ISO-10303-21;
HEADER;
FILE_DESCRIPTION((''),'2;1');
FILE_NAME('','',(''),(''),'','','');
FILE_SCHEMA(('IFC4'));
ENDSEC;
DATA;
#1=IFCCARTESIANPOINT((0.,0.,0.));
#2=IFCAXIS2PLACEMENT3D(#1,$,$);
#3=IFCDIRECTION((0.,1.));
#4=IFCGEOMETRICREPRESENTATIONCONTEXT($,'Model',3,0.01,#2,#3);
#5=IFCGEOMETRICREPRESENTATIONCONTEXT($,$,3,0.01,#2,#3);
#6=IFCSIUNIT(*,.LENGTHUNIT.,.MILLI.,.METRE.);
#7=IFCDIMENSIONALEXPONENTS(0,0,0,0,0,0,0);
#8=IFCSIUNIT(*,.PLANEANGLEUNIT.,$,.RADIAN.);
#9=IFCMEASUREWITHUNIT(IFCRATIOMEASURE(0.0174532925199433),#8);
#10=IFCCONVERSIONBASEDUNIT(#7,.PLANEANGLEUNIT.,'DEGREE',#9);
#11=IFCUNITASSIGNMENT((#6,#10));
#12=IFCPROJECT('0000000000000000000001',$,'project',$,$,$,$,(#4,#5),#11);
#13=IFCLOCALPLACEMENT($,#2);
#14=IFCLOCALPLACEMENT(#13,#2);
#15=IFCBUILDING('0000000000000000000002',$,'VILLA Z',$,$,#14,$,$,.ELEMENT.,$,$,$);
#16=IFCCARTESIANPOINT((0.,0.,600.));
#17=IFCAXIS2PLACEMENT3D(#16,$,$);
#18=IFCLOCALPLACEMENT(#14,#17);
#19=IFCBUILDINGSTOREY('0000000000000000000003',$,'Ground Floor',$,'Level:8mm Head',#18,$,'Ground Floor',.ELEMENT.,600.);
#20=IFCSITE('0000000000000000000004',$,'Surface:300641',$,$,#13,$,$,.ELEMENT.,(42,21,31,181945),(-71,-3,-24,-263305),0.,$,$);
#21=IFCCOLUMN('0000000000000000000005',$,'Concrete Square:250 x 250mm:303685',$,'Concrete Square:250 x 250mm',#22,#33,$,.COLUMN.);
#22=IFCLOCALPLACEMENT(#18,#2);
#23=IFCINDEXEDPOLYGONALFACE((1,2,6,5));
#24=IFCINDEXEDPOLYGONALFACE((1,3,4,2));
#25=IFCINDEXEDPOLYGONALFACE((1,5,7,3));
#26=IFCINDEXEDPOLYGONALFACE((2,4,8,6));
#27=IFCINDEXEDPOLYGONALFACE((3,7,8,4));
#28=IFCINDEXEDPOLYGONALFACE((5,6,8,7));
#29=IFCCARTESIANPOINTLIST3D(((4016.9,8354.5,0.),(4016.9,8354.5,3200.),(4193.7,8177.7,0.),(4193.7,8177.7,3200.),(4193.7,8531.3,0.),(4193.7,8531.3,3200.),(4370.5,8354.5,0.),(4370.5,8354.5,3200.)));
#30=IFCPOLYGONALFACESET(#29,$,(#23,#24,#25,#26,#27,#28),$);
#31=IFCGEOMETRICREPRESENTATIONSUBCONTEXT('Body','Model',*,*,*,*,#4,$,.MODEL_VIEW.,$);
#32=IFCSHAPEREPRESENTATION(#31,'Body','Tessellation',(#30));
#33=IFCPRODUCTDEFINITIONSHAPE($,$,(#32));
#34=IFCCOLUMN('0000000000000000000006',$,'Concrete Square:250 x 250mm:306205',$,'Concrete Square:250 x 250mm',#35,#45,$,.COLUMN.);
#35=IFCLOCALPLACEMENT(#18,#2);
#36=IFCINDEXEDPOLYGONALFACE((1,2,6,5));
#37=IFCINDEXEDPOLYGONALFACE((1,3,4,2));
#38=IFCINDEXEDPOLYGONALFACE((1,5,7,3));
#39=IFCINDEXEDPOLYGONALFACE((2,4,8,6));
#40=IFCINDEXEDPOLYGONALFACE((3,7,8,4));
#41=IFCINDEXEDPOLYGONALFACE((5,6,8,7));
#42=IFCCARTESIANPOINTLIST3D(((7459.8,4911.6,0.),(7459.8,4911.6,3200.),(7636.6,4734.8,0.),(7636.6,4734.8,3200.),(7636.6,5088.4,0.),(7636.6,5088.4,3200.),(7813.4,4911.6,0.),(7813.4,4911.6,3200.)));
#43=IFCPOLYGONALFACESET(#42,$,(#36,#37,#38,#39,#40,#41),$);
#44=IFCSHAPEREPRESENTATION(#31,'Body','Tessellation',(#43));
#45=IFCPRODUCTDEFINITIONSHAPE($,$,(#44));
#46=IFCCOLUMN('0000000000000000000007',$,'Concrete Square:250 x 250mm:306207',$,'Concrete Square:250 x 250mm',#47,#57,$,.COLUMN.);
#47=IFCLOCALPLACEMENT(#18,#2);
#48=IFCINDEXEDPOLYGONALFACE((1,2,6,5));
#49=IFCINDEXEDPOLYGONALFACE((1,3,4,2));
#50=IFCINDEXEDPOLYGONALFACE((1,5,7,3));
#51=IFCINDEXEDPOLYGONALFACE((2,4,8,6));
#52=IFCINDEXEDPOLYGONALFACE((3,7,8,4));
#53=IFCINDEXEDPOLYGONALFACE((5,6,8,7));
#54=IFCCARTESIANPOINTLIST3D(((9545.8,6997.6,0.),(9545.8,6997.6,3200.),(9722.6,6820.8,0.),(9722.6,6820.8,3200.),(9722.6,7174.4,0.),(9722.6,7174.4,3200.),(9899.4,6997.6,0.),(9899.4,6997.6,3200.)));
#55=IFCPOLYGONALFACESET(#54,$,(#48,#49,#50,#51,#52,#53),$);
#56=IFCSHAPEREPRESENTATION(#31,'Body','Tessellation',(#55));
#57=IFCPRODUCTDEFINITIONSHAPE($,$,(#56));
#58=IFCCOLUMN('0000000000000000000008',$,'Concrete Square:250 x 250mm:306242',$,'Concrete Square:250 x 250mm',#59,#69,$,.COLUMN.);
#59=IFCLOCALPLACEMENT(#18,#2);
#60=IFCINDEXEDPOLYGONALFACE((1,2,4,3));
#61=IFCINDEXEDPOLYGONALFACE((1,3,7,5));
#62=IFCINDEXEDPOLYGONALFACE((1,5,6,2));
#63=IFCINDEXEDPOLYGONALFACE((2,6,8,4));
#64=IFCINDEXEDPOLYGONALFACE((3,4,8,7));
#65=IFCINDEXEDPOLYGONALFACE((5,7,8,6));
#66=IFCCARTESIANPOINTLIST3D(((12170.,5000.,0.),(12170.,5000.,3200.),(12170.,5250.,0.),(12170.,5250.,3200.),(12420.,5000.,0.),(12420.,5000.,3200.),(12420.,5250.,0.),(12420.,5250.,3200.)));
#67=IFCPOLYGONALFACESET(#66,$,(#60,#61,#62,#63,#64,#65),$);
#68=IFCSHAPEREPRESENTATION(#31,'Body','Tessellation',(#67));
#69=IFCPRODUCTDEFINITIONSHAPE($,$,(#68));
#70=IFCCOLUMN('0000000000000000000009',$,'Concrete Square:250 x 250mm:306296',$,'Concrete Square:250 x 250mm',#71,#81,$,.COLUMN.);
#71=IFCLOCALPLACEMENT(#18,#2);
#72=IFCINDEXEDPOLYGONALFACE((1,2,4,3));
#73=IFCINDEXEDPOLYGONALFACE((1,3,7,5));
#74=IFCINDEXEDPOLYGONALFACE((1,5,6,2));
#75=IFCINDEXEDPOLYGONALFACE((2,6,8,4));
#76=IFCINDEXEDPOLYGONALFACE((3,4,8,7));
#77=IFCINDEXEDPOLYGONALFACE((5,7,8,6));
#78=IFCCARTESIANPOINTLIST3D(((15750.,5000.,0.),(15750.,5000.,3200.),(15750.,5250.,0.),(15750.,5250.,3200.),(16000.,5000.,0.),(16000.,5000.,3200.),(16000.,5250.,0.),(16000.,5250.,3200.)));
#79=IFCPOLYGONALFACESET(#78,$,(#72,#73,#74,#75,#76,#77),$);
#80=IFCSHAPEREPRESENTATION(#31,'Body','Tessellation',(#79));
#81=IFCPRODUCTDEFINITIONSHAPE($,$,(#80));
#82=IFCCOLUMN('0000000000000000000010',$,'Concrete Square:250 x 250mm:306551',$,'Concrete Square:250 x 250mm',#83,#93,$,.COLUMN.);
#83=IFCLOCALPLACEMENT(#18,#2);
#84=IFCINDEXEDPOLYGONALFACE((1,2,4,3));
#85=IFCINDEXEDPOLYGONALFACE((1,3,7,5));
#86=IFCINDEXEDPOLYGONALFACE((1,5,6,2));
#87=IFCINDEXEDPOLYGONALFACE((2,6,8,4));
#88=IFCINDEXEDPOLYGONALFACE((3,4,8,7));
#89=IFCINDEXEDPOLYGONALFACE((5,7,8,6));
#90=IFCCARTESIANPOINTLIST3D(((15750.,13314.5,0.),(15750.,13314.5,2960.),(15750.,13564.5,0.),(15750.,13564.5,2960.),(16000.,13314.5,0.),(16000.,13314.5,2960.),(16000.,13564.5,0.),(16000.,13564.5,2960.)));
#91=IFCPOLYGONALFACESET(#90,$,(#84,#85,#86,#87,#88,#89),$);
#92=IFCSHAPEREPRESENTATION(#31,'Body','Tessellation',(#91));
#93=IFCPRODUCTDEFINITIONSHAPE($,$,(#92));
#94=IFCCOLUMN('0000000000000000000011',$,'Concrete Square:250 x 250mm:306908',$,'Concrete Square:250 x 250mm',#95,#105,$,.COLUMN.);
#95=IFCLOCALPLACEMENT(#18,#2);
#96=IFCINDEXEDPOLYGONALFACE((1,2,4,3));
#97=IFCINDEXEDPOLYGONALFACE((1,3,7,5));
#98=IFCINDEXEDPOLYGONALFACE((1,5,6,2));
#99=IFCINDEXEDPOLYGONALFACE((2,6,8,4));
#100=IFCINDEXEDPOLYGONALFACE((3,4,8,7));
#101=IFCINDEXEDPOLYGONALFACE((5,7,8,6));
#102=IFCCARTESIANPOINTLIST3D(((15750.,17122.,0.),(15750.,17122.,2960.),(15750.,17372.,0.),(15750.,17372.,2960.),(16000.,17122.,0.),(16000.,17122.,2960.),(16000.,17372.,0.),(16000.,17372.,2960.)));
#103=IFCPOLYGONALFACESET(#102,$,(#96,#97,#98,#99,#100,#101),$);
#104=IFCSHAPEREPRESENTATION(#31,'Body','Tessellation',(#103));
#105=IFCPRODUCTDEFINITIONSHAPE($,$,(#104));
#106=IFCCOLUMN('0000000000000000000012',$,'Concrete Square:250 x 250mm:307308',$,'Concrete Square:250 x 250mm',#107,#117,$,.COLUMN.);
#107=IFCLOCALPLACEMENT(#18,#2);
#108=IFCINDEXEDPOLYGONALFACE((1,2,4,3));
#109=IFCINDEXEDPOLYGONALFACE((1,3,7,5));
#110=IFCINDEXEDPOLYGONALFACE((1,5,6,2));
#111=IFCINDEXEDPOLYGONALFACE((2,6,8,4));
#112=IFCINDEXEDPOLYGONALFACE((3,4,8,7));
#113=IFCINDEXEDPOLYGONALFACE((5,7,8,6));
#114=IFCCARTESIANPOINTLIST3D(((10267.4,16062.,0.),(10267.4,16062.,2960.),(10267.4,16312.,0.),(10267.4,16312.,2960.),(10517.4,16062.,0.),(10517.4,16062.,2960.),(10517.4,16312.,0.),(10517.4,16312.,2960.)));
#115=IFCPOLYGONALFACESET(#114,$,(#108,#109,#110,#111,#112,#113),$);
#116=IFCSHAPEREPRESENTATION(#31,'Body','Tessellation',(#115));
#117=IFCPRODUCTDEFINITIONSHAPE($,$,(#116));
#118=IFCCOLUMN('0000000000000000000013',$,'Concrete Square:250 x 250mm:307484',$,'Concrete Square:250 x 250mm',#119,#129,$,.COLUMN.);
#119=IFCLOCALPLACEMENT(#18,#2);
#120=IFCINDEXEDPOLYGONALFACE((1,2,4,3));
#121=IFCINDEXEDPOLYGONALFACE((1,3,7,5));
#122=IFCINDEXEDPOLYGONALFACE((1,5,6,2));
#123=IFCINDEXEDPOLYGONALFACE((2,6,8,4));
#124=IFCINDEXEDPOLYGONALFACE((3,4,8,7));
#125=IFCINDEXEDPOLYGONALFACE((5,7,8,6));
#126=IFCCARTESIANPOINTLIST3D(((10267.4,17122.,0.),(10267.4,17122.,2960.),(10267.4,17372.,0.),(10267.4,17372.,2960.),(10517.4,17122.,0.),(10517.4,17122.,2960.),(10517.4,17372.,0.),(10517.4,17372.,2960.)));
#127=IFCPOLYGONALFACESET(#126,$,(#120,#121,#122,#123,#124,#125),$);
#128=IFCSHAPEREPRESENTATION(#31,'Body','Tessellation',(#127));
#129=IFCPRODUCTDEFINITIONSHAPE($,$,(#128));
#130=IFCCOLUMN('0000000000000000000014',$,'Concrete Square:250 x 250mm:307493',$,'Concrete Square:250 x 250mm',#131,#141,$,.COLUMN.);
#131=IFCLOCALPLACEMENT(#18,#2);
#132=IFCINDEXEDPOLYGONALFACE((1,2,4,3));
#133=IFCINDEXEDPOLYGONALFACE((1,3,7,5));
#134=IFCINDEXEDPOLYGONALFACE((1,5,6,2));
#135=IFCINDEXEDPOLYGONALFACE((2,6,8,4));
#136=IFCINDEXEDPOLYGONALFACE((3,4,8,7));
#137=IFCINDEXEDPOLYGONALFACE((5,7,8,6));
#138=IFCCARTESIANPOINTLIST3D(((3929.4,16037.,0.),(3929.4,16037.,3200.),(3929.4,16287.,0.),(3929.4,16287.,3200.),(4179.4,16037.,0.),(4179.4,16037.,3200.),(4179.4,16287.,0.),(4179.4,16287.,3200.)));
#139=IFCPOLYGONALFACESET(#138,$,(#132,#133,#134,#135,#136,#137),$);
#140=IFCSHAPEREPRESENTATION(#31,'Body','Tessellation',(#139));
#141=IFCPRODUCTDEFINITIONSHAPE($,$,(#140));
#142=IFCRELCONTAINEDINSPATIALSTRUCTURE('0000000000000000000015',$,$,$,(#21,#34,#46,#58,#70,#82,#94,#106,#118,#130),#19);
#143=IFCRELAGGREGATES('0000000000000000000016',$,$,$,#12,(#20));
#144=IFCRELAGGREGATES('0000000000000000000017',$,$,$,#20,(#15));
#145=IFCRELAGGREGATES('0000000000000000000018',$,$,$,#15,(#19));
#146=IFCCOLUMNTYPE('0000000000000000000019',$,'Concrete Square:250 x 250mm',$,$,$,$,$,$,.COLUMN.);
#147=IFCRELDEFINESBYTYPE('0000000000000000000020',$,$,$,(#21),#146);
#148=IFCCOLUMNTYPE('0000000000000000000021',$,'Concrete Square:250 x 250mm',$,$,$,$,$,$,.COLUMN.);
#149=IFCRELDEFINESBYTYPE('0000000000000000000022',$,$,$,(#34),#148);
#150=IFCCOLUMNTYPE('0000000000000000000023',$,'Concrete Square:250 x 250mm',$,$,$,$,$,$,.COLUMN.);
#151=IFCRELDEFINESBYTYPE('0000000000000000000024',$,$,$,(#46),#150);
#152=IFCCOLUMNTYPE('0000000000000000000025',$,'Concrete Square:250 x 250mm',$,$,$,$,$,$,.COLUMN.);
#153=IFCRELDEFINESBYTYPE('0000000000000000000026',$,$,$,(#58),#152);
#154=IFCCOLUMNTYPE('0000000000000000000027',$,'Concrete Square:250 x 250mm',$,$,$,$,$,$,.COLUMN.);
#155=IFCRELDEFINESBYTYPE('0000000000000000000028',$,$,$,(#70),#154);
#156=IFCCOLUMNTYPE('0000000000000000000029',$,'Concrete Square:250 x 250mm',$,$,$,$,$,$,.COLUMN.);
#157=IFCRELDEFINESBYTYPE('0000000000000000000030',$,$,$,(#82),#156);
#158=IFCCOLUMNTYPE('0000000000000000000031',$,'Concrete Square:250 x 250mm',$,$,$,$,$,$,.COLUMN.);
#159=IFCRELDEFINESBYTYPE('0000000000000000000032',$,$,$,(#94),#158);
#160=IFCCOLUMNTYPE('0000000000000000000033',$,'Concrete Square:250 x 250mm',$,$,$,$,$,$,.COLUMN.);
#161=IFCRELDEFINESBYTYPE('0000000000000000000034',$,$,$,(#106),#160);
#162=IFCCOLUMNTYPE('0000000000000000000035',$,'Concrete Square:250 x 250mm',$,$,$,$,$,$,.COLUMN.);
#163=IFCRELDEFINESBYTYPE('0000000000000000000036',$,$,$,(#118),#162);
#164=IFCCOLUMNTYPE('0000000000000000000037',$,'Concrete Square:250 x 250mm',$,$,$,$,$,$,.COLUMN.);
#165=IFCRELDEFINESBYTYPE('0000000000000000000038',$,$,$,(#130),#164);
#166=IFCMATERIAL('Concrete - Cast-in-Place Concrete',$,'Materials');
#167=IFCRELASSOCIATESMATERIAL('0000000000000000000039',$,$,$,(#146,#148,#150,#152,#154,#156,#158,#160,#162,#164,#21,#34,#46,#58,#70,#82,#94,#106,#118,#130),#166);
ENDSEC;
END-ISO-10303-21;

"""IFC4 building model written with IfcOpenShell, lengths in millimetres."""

from ifc_helpers import new_model, entity, si_unit, converted_unit, direction, frame, frame_2d, origin, origin_2d_with_axis, place, context, subcontext, project, spatial, rectangle, extrude, source, transform, mapped, material, material_profile, profile_set, profile_usage, type_object, type_shapes, element, save


model = new_model("IFC4")

# Units and contexts
model_context = context("Model", 3, precision=0.01, world=origin(), true_north=direction((0.0, 1.0)))
context_of_model = context(None, 3, precision=0.01, world=origin(), true_north=direction((0.0, 1.0)))
body_context = subcontext(model_context, "Body", "Model", "MODEL_VIEW")
ifc_project = project(units=[si_unit("LENGTHUNIT", "METRE", prefix="MILLI"), converted_unit("PLANEANGLEUNIT", "DEGREE", entity("IfcRatioMeasure", 0.0174532925199433), si_unit("PLANEANGLEUNIT", "RADIAN"), dimensions=[0, 0, 0, 0, 0, 0, 0])], contexts=[model_context, context_of_model])

# Site, building, storey
site_placement = place(None, origin())
site = spatial("IfcSite", under=ifc_project, at=site_placement, Name="Surface:300641", CompositionType="ELEMENT", RefLatitude=(42, 21, 31, 181945), RefLongitude=(-71, -3, -24, -263305), RefElevation=0.0)
building_placement = place(site_placement, origin())
building = spatial("IfcBuilding", under=site, at=building_placement, Name="VILLA Z", CompositionType="ELEMENT")
storey_placement = place(building_placement, frame((0.0, 0.0, 600.0)))
storey = spatial("IfcBuildingStorey", under=building, at=storey_placement, Name="Ground Floor", ObjectType="Level:8mm Head", LongName="Ground Floor", CompositionType="ELEMENT", Elevation=600.0)

# Columns
ifc_material_1 = material(Name="Concrete - Cast-in-Place Concrete", Category="Materials")
ifc_material_profile_1 = material_profile(ifc_material_1, rectangle(XDim=250.0, YDim=250.0, at=frame_2d((0.0, 0.0), x_axis=(1.0, 0.0))), Name="250 x 250mm")
ifc_profile_set_1 = profile_set([ifc_material_profile_1], Name="250 x 250mm")
ifc_profile_usage_1 = profile_usage(ifc_profile_set_1)
column_type_1 = type_object("IfcColumnType", Name="Concrete Square:250 x 250mm", PredefinedType="COLUMN", material=ifc_profile_set_1)
shared_shape_1 = source(origin(), body_context, "Body", "SweptSolid", [
    extrude(rectangle(XDim=250.0, YDim=250.0, at=frame_2d((0.0, 0.0), x_axis=(1.0, 0.0))), frame((4193.7, 8354.5, 600.0), z_axis=(0.0, 0.0, 1.0), x_axis=(-0.707107, 0.707107, 0.0)), (0.0, 0.0, 1.0), 3200.0),
])
type_shapes(column_type_1, [shared_shape_1])
column_1_placement = place(storey_placement, frame((0.0, 0.0, -600.0)))
element("IfcColumn", 1, at=column_1_placement, inside=storey, type_object=column_type_1, material=ifc_profile_usage_1, Name="Concrete Square:250 x 250mm:303685", ObjectType="Concrete Square:250 x 250mm", PredefinedType="COLUMN", context=body_context, shape_type="MappedRepresentation", body=[
    mapped(shared_shape_1, transform((0.0, 0.0, 0.0), scale=1.0)),
])
ifc_profile_usage_2 = profile_usage(ifc_profile_set_1)
column_type_2 = type_object("IfcColumnType", Name="Concrete Square:250 x 250mm", PredefinedType="COLUMN", material=ifc_profile_set_1)
shared_shape_2 = source(origin(), body_context, "Body", "SweptSolid", [
    extrude(rectangle(XDim=250.0, YDim=250.0, at=frame_2d((0.0, 0.0), x_axis=(1.0, 0.0))), frame((7636.6, 4911.6, 600.0), z_axis=(0.0, 0.0, 1.0), x_axis=(-0.707107, 0.707107, 0.0)), (0.0, 0.0, 1.0), 3200.0),
])
type_shapes(column_type_2, [shared_shape_2])
column_2_placement = place(storey_placement, frame((0.0, 0.0, -600.0)))
element("IfcColumn", 2, at=column_2_placement, inside=storey, type_object=column_type_2, material=ifc_profile_usage_2, Name="Concrete Square:250 x 250mm:306205", ObjectType="Concrete Square:250 x 250mm", PredefinedType="COLUMN", context=body_context, shape_type="MappedRepresentation", body=[
    mapped(shared_shape_2, transform((0.0, 0.0, 0.0), scale=1.0)),
])
ifc_profile_usage_3 = profile_usage(ifc_profile_set_1)
column_type_3 = type_object("IfcColumnType", Name="Concrete Square:250 x 250mm", PredefinedType="COLUMN", material=ifc_profile_set_1)
shared_shape_3 = source(origin(), body_context, "Body", "SweptSolid", [
    extrude(rectangle(XDim=250.0, YDim=250.0, at=frame_2d((0.0, 0.0), x_axis=(1.0, 0.0))), frame((9722.6, 6997.6, 600.0), z_axis=(0.0, 0.0, 1.0), x_axis=(-0.707107, 0.707107, 0.0)), (0.0, 0.0, 1.0), 3200.0),
])
type_shapes(column_type_3, [shared_shape_3])
column_3_placement = place(storey_placement, frame((0.0, 0.0, -600.0)))
element("IfcColumn", 3, at=column_3_placement, inside=storey, type_object=column_type_3, material=ifc_profile_usage_3, Name="Concrete Square:250 x 250mm:306207", ObjectType="Concrete Square:250 x 250mm", PredefinedType="COLUMN", context=body_context, shape_type="MappedRepresentation", body=[
    mapped(shared_shape_3, transform((0.0, 0.0, 0.0), scale=1.0)),
])
ifc_profile_usage_4 = profile_usage(ifc_profile_set_1)
column_type_4 = type_object("IfcColumnType", Name="Concrete Square:250 x 250mm", PredefinedType="COLUMN", material=ifc_profile_set_1)
shared_shape_4 = source(origin(), body_context, "Body", "SweptSolid", [
    extrude(rectangle(XDim=250.0, YDim=250.0, at=origin_2d_with_axis()), frame((12295.0, 5125.0, 600.0), z_axis=(0.0, 0.0, 1.0), x_axis=(0.0, -1.0, 0.0)), (0.0, 0.0, 1.0), 3200.0),
])
type_shapes(column_type_4, [shared_shape_4])
column_4_placement = place(storey_placement, frame((0.0, 0.0, -600.0)))
element("IfcColumn", 4, at=column_4_placement, inside=storey, type_object=column_type_4, material=ifc_profile_usage_4, Name="Concrete Square:250 x 250mm:306242", ObjectType="Concrete Square:250 x 250mm", PredefinedType="COLUMN", context=body_context, shape_type="MappedRepresentation", body=[
    mapped(shared_shape_4, transform((0.0, 0.0, 0.0), scale=1.0)),
])
ifc_profile_usage_5 = profile_usage(ifc_profile_set_1)
column_type_5 = type_object("IfcColumnType", Name="Concrete Square:250 x 250mm", PredefinedType="COLUMN", material=ifc_profile_set_1)
shared_shape_5 = source(origin(), body_context, "Body", "SweptSolid", [
    extrude(rectangle(XDim=250.0, YDim=250.0, at=origin_2d_with_axis()), frame((15875.0, 5125.0, 600.0), z_axis=(0.0, 0.0, 1.0), x_axis=(0.0, -1.0, 0.0)), (0.0, 0.0, 1.0), 3200.0),
])
type_shapes(column_type_5, [shared_shape_5])
column_5_placement = place(storey_placement, frame((0.0, 0.0, -600.0)))
element("IfcColumn", 5, at=column_5_placement, inside=storey, type_object=column_type_5, material=ifc_profile_usage_5, Name="Concrete Square:250 x 250mm:306296", ObjectType="Concrete Square:250 x 250mm", PredefinedType="COLUMN", context=body_context, shape_type="MappedRepresentation", body=[
    mapped(shared_shape_5, transform((0.0, 0.0, 0.0), scale=1.0)),
])
ifc_profile_usage_6 = profile_usage(ifc_profile_set_1)
column_type_6 = type_object("IfcColumnType", Name="Concrete Square:250 x 250mm", PredefinedType="COLUMN", material=ifc_profile_set_1)
shared_shape_6 = source(origin(), body_context, "Body", "SweptSolid", [
    extrude(rectangle(XDim=250.0, YDim=250.0, at=frame_2d((0.0, 0.0), x_axis=(1.0, 0.0))), frame((15875.0, 13439.5, 600.0), z_axis=(0.0, 0.0, 1.0), x_axis=(0.0, -1.0, 0.0)), (0.0, 0.0, 1.0), 2960.0),
])
type_shapes(column_type_6, [shared_shape_6])
column_6_placement = place(storey_placement, frame((0.0, 0.0, -600.0)))
element("IfcColumn", 6, at=column_6_placement, inside=storey, type_object=column_type_6, material=ifc_profile_usage_6, Name="Concrete Square:250 x 250mm:306551", ObjectType="Concrete Square:250 x 250mm", PredefinedType="COLUMN", context=body_context, shape_type="MappedRepresentation", body=[
    mapped(shared_shape_6, transform((0.0, 0.0, 0.0), scale=1.0)),
])
ifc_profile_usage_7 = profile_usage(ifc_profile_set_1)
column_type_7 = type_object("IfcColumnType", Name="Concrete Square:250 x 250mm", PredefinedType="COLUMN", material=ifc_profile_set_1)
shared_shape_7 = source(origin(), body_context, "Body", "SweptSolid", [
    extrude(rectangle(XDim=250.0, YDim=250.0, at=origin_2d_with_axis()), frame((15875.0, 17247.0, 600.0), z_axis=(0.0, 0.0, 1.0), x_axis=(0.0, -1.0, 0.0)), (0.0, 0.0, 1.0), 2960.0),
])
type_shapes(column_type_7, [shared_shape_7])
column_7_placement = place(storey_placement, frame((0.0, 0.0, -600.0)))
element("IfcColumn", 7, at=column_7_placement, inside=storey, type_object=column_type_7, material=ifc_profile_usage_7, Name="Concrete Square:250 x 250mm:306908", ObjectType="Concrete Square:250 x 250mm", PredefinedType="COLUMN", context=body_context, shape_type="MappedRepresentation", body=[
    mapped(shared_shape_7, transform((0.0, 0.0, 0.0), scale=1.0)),
])
ifc_profile_usage_8 = profile_usage(ifc_profile_set_1)
column_type_8 = type_object("IfcColumnType", Name="Concrete Square:250 x 250mm", PredefinedType="COLUMN", material=ifc_profile_set_1)
shared_shape_8 = source(origin(), body_context, "Body", "SweptSolid", [
    extrude(rectangle(XDim=250.0, YDim=250.0, at=frame_2d((0.0, 0.0), x_axis=(1.0, 0.0))), frame((10392.4, 16187.0, 600.0), z_axis=(0.0, 0.0, 1.0), x_axis=(0.0, -1.0, 0.0)), (0.0, 0.0, 1.0), 2960.0),
])
type_shapes(column_type_8, [shared_shape_8])
column_8_placement = place(storey_placement, frame((0.0, 0.0, -600.0)))
element("IfcColumn", 8, at=column_8_placement, inside=storey, type_object=column_type_8, material=ifc_profile_usage_8, Name="Concrete Square:250 x 250mm:307308", ObjectType="Concrete Square:250 x 250mm", PredefinedType="COLUMN", context=body_context, shape_type="MappedRepresentation", body=[
    mapped(shared_shape_8, transform((0.0, 0.0, 0.0), scale=1.0)),
])
ifc_profile_usage_9 = profile_usage(ifc_profile_set_1)
column_type_9 = type_object("IfcColumnType", Name="Concrete Square:250 x 250mm", PredefinedType="COLUMN", material=ifc_profile_set_1)
shared_shape_9 = source(origin(), body_context, "Body", "SweptSolid", [
    extrude(rectangle(XDim=250.0, YDim=250.0, at=origin_2d_with_axis()), frame((10392.4, 17247.0, 600.0), z_axis=(0.0, 0.0, 1.0), x_axis=(0.0, -1.0, 0.0)), (0.0, 0.0, 1.0), 2960.0),
])
type_shapes(column_type_9, [shared_shape_9])
column_9_placement = place(storey_placement, frame((0.0, 0.0, -600.0)))
element("IfcColumn", 9, at=column_9_placement, inside=storey, type_object=column_type_9, material=ifc_profile_usage_9, Name="Concrete Square:250 x 250mm:307484", ObjectType="Concrete Square:250 x 250mm", PredefinedType="COLUMN", context=body_context, shape_type="MappedRepresentation", body=[
    mapped(shared_shape_9, transform((0.0, 0.0, 0.0), scale=1.0)),
])
ifc_profile_usage_10 = profile_usage(ifc_profile_set_1)
column_type_10 = type_object("IfcColumnType", Name="Concrete Square:250 x 250mm", PredefinedType="COLUMN", material=ifc_profile_set_1)
shared_shape_10 = source(origin(), body_context, "Body", "SweptSolid", [
    extrude(rectangle(XDim=250.0, YDim=250.0, at=frame_2d((0.0, 0.0), x_axis=(1.0, 0.0))), frame((4054.4, 16162.0, 600.0), z_axis=(0.0, 0.0, 1.0), x_axis=(0.0, -1.0, 0.0)), (0.0, 0.0, 1.0), 3200.0),
])
type_shapes(column_type_10, [shared_shape_10])
column_10_placement = place(storey_placement, frame((0.0, 0.0, -600.0)))
element("IfcColumn", 10, at=column_10_placement, inside=storey, type_object=column_type_10, material=ifc_profile_usage_10, Name="Concrete Square:250 x 250mm:307493", ObjectType="Concrete Square:250 x 250mm", PredefinedType="COLUMN", context=body_context, shape_type="MappedRepresentation", body=[
    mapped(shared_shape_10, transform((0.0, 0.0, 0.0), scale=1.0)),
])

save(model, "model.ifc")
